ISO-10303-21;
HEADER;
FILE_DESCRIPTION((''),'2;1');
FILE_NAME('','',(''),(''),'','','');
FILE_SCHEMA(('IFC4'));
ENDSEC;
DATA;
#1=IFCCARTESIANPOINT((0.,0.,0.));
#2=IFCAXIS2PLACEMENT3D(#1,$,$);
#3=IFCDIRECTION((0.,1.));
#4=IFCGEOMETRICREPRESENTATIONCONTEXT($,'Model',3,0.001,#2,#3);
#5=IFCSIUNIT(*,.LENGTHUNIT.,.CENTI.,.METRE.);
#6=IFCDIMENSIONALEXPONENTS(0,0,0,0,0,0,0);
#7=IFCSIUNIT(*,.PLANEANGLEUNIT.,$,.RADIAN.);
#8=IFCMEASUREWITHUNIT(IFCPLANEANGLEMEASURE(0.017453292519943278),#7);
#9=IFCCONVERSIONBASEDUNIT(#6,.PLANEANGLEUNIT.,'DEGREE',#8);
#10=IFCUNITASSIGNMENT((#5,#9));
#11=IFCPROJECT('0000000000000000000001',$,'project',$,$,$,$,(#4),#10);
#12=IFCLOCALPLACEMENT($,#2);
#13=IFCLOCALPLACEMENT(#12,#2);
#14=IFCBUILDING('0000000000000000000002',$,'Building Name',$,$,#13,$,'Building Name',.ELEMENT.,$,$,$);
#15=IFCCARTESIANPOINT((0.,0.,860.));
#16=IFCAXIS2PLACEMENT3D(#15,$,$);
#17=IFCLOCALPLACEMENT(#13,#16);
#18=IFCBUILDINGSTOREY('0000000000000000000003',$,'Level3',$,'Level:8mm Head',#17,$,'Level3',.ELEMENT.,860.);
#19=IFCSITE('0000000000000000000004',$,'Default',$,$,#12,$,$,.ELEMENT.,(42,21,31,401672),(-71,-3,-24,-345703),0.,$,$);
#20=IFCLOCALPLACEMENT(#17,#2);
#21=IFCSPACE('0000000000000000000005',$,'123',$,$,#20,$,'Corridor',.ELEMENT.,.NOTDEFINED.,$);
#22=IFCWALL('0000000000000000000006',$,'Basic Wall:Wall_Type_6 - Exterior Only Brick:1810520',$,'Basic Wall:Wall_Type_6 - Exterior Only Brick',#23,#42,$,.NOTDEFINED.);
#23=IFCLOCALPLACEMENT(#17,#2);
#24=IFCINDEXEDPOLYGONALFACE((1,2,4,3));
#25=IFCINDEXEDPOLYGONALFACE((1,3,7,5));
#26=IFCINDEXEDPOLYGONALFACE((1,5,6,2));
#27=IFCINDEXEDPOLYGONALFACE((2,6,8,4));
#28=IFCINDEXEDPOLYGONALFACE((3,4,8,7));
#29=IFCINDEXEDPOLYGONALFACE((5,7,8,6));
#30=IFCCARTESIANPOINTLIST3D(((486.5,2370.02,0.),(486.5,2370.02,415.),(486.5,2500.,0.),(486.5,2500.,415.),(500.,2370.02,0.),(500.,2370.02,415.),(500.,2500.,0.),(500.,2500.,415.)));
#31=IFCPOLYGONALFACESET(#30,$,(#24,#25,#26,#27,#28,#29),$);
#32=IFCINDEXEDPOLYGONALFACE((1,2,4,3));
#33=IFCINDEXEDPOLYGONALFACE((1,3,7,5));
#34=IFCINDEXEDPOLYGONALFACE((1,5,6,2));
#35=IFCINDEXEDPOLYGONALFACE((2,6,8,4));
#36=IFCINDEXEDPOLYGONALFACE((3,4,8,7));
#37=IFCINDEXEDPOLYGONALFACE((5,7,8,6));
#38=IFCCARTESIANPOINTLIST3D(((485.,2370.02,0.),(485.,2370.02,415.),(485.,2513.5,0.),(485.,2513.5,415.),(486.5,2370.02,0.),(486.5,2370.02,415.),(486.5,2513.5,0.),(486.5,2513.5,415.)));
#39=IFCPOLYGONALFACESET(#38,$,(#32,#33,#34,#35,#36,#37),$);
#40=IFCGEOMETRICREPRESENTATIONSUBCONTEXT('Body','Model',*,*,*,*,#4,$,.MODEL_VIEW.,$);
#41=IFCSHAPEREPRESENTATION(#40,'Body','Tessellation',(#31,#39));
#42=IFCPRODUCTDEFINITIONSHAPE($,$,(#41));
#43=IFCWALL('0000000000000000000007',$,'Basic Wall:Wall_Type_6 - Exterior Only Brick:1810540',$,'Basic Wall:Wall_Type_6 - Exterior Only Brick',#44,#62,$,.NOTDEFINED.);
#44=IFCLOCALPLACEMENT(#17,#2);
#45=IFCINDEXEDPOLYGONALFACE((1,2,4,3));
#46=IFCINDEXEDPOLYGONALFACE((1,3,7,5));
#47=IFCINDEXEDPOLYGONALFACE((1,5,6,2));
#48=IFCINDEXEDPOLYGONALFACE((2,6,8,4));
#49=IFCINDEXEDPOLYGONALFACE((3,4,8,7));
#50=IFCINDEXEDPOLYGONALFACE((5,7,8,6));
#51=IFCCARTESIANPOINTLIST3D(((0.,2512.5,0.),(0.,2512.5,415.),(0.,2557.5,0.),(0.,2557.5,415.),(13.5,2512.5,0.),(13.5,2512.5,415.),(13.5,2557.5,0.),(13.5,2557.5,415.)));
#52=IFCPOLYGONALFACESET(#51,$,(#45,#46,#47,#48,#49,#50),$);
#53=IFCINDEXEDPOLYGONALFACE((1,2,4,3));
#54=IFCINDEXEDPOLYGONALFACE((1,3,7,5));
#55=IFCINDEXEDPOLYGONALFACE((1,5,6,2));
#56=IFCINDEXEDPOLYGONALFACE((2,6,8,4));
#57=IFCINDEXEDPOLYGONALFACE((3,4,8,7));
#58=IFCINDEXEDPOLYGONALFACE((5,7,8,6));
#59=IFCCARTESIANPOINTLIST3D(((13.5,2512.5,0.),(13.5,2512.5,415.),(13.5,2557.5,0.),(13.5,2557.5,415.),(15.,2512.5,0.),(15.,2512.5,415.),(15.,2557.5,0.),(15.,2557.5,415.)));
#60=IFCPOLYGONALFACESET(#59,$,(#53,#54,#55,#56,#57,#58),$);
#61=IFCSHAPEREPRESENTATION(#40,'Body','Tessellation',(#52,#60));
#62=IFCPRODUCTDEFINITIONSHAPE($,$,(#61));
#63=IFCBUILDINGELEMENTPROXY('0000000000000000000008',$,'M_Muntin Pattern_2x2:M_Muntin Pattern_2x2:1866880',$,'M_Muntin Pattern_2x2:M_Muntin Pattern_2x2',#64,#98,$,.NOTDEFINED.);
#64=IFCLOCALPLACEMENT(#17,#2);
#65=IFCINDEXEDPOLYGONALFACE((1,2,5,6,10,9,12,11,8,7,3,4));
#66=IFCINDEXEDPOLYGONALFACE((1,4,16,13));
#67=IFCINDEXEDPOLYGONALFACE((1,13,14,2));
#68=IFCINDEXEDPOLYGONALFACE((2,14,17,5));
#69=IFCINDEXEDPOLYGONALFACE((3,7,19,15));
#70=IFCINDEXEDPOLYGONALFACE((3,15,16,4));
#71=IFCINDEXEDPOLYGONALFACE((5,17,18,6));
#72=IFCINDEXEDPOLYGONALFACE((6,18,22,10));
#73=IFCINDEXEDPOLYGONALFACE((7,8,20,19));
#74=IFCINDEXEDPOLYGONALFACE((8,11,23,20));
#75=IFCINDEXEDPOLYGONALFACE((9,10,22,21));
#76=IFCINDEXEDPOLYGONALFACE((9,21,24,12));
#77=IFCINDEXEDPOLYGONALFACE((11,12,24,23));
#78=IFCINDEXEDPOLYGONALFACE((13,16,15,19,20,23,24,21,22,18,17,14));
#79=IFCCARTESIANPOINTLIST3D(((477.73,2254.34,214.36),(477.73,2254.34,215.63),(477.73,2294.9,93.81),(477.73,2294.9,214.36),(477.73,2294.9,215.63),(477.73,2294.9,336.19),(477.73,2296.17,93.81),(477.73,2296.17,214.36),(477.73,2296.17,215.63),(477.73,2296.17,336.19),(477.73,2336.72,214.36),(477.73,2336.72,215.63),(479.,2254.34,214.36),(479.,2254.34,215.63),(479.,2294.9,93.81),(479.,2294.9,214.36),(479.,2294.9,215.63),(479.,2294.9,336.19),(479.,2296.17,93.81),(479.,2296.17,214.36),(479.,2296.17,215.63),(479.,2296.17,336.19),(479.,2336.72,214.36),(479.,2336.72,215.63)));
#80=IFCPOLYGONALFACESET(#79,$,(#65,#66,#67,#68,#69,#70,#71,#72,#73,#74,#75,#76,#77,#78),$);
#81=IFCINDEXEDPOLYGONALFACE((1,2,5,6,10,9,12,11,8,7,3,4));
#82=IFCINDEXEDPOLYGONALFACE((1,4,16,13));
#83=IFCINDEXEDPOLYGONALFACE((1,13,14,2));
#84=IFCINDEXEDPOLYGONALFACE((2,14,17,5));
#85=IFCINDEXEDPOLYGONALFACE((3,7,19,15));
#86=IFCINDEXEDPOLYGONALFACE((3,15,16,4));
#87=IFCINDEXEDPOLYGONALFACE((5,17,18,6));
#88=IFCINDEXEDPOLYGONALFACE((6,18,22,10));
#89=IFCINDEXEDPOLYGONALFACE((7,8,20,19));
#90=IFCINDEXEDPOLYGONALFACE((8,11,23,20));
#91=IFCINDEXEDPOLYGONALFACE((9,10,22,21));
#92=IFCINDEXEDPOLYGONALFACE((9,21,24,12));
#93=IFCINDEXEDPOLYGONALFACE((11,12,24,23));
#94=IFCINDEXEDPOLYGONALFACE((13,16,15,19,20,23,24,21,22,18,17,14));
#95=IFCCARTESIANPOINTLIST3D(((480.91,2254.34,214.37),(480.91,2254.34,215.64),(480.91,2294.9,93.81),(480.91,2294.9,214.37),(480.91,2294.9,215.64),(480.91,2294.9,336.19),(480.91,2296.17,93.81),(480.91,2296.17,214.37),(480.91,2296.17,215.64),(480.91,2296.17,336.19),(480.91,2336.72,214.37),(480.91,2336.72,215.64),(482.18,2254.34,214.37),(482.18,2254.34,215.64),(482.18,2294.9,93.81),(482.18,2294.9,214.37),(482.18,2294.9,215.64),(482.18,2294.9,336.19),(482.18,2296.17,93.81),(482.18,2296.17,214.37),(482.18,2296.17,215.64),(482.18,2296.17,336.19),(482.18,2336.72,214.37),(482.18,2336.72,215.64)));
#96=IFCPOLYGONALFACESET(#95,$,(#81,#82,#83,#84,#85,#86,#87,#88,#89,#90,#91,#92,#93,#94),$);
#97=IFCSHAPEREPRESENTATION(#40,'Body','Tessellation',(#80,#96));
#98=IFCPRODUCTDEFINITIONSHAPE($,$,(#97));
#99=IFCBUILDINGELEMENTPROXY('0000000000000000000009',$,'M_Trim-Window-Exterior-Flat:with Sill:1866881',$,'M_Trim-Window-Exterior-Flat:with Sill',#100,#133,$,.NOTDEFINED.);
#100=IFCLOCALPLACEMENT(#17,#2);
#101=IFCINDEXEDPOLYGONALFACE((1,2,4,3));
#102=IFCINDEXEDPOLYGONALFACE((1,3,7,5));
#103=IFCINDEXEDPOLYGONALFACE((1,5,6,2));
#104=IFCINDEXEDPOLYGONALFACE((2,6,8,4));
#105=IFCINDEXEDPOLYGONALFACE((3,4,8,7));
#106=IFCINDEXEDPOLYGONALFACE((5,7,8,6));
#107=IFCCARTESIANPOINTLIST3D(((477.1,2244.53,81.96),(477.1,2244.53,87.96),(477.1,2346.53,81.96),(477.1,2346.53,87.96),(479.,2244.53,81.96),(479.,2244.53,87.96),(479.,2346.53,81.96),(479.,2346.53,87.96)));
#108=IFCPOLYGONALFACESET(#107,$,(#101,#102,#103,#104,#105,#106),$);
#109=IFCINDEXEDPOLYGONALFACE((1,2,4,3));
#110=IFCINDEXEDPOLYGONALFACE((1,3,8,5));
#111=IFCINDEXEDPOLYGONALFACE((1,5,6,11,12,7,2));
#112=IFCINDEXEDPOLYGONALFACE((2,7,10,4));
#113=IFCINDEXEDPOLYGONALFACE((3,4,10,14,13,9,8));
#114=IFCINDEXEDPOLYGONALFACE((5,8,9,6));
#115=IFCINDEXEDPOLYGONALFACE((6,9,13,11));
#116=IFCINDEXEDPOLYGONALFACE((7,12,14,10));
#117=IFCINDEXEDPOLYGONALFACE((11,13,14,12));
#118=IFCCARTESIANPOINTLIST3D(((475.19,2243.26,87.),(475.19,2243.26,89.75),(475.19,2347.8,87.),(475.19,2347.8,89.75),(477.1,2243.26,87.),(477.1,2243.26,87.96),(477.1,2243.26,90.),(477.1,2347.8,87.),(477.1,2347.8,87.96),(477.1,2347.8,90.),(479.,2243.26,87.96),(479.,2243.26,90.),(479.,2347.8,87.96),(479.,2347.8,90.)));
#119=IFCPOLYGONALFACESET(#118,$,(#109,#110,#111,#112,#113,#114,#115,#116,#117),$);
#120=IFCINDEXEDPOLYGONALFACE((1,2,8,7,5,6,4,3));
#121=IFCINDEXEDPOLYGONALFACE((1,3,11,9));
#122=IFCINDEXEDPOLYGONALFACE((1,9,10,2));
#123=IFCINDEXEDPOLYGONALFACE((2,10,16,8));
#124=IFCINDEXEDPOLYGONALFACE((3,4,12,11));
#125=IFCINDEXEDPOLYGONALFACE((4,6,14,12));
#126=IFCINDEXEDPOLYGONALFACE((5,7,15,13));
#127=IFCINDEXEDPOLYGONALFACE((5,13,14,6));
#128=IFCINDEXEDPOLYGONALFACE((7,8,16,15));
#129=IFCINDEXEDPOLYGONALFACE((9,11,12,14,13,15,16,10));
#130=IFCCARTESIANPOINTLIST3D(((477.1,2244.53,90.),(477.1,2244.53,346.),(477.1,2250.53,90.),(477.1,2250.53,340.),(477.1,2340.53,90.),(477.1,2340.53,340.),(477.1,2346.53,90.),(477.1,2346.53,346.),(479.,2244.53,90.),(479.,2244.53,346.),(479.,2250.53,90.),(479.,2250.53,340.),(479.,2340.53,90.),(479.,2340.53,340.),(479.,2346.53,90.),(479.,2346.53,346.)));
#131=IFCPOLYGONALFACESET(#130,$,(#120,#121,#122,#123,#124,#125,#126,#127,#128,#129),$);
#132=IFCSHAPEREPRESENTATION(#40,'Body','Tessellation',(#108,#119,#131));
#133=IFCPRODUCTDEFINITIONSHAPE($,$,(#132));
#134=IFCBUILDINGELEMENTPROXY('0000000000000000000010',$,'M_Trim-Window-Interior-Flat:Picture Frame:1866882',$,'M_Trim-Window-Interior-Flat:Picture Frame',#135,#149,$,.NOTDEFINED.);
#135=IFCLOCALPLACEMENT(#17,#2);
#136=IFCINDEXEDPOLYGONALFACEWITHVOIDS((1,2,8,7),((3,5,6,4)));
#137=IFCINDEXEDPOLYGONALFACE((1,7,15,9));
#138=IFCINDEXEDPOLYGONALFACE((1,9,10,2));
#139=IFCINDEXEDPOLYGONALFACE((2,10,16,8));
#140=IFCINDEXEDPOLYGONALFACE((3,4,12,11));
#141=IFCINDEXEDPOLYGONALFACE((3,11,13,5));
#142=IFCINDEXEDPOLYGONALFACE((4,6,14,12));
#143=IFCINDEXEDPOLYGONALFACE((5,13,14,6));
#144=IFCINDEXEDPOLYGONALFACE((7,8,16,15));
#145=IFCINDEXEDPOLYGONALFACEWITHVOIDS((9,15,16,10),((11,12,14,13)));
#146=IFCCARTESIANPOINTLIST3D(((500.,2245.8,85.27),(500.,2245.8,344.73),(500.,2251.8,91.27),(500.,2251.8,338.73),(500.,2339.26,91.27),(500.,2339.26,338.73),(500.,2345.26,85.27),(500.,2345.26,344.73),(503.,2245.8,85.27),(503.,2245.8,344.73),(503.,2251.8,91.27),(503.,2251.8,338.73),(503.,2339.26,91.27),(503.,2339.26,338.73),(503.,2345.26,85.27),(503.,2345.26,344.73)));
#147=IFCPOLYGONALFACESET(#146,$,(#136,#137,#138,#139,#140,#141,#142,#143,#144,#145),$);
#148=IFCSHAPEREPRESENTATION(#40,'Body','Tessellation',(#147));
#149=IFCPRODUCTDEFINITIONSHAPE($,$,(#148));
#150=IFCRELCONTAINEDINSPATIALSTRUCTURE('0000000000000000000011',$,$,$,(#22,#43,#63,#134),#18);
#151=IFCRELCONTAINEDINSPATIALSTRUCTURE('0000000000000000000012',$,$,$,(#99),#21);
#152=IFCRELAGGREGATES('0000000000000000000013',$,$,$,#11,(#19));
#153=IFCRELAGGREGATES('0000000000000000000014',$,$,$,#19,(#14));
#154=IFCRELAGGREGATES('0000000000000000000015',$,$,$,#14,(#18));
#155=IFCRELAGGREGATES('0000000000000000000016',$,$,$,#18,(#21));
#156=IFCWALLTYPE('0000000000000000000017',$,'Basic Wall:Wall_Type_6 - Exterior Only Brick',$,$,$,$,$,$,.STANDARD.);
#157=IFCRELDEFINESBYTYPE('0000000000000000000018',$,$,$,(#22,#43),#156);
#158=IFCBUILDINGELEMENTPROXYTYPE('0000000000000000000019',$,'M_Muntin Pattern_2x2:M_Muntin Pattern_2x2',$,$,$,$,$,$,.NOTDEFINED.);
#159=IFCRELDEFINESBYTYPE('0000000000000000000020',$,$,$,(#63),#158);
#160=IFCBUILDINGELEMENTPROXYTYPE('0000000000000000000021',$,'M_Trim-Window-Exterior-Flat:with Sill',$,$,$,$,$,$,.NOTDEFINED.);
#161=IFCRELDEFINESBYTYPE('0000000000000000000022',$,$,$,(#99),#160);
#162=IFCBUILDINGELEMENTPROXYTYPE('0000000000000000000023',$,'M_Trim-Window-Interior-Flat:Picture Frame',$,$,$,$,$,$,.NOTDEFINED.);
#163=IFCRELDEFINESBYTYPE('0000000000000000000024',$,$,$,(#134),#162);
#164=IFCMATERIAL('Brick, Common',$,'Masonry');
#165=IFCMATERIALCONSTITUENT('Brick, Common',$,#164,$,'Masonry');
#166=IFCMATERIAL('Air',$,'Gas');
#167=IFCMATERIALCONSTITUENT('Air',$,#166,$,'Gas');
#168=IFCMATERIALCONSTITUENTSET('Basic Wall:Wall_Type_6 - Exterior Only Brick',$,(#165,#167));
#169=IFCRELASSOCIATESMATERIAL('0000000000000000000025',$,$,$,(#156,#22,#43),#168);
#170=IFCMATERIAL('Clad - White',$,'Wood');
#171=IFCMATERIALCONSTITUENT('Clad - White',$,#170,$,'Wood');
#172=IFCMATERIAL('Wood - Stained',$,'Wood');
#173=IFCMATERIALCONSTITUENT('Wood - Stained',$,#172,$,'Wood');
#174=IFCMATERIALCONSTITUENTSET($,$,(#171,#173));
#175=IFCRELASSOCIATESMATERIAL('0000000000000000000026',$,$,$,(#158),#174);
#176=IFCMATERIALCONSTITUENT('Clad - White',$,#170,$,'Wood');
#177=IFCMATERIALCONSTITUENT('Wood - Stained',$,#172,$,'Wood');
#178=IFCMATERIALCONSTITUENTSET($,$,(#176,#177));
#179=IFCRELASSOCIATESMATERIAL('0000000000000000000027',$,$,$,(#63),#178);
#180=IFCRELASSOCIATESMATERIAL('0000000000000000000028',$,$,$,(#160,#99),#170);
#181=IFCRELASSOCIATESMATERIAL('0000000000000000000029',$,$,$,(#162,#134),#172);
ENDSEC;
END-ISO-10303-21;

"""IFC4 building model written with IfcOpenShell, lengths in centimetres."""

from ifc_helpers import new_model, entity, si_unit, converted_unit, direction, frame, origin, place, context, subcontext, project, spatial, indexed_curve, outline, extrude, source, transform, mapped, material, constituent, constituent_set, type_object, type_shapes, element, save


model = new_model("IFC4")

# Units and contexts
model_context = context("Model", 3, precision=0.001, world=origin(), true_north=direction((0.0, 1.0)))
body_context = subcontext(model_context, "Body", "Model", "MODEL_VIEW")
ifc_project = project(units=[si_unit("LENGTHUNIT", "METRE", prefix="CENTI"), converted_unit("PLANEANGLEUNIT", "DEGREE", entity("IfcPlaneAngleMeasure", 0.017453292519943278), si_unit("PLANEANGLEUNIT", "RADIAN"), dimensions=[0, 0, 0, 0, 0, 0, 0])], contexts=[model_context])

# Site, building, storey
site_placement = place(None, origin())
site = spatial("IfcSite", under=ifc_project, at=site_placement, Name="Default", CompositionType="ELEMENT", RefLatitude=(42, 21, 31, 401672), RefLongitude=(-71, -3, -24, -345703), RefElevation=0.0)
building_placement = place(site_placement, origin())
building = spatial("IfcBuilding", under=site, at=building_placement, Name="Building Name", LongName="Building Name", CompositionType="ELEMENT")
storey_placement = place(building_placement, frame((0.0, 0.0, 860.0)))
storey = spatial("IfcBuildingStorey", under=building, at=storey_placement, Name="Level3", ObjectType="Level:8mm Head", LongName="Level3", CompositionType="ELEMENT", Elevation=860.0)

# Shared definitions
ifc_material_1 = material(Name="Brick, Common", Category="Masonry")
ifc_material_2 = material(Name="Air", Category="Gas")

# Walls
ifc_constituent_1 = constituent(ifc_material_1, Name="Brick, Common", Category="Masonry")
ifc_constituent_2 = constituent(ifc_material_2, Name="Air", Category="Gas")
ifc_constituent_set_1 = constituent_set(constituents=[ifc_constituent_1, ifc_constituent_2], Name="Basic Wall:Wall_Type_6 - Exterior Only Brick")
wall_type_1 = type_object("IfcWallType", Name="Basic Wall:Wall_Type_6 - Exterior Only Brick", PredefinedType="STANDARD", material=ifc_constituent_set_1)
wall_1_placement = place(storey_placement, frame((492.5, 2500.0, 0.0), z_axis=(0.0, 0.0, 1.0), x_axis=(0.0, -1.0, 0.0)))
element("IfcWall", 1, at=wall_1_placement, inside=storey, type_object=wall_type_1, material=ifc_constituent_set_1, Name="Basic Wall:Wall_Type_6 - Exterior Only Brick:1810520", ObjectType="Basic Wall:Wall_Type_6 - Exterior Only Brick", PredefinedType="NOTDEFINED", context=body_context, shape_type="SweptSolid", body=[
    extrude(outline(indexed_curve([(-6.75, -64.99), (6.75, -64.99), (6.75, 64.99), (-6.75, 64.99), (-6.75, -64.99)], self_intersect=False)), frame((64.99, 0.75, 0.0), z_axis=(0.0, 0.0, 1.0), x_axis=(0.0, -1.0, 0.0)), (0.0, 0.0, 1.0), 415.0),
    extrude(outline(indexed_curve([(-0.75, -71.74), (0.75, -71.74), (0.75, 71.74), (-0.75, 71.74), (-0.75, -71.74)], self_intersect=False)), frame((58.24, -6.75, 0.0), z_axis=(0.0, 0.0, 1.0), x_axis=(0.0, 1.0, 0.0)), (0.0, 0.0, 1.0), 415.0),
])
wall_2_placement = place(storey_placement, frame((7.5, 2512.5, 0.0), z_axis=(0.0, 0.0, 1.0), x_axis=(0.0, 1.0, 0.0)))
element("IfcWall", 2, at=wall_2_placement, inside=storey, type_object=wall_type_1, material=ifc_constituent_set_1, Name="Basic Wall:Wall_Type_6 - Exterior Only Brick:1810540", ObjectType="Basic Wall:Wall_Type_6 - Exterior Only Brick", PredefinedType="NOTDEFINED", context=body_context, shape_type="SweptSolid", body=[
    extrude(outline(indexed_curve([(-6.75, -22.5), (6.75, -22.5), (6.75, 22.5), (-6.75, 22.5), (-6.75, -22.5)], self_intersect=False)), frame((22.5, 0.75, 0.0), z_axis=(0.0, 0.0, 1.0), x_axis=(0.0, -1.0, 0.0)), (0.0, 0.0, 1.0), 415.0),
    extrude(outline(indexed_curve([(-0.75, -22.5), (0.75, -22.5), (0.75, 22.5), (-0.75, 22.5), (-0.75, -22.5)], self_intersect=False)), frame((22.5, -6.75, 0.0), z_axis=(0.0, 0.0, 1.0), x_axis=(0.0, 1.0, 0.0)), (0.0, 0.0, 1.0), 415.0),
])

# Building element proxy
ifc_material_3 = material(Name="Clad - White", Category="Wood")
ifc_constituent_3 = constituent(ifc_material_3, Name="Clad - White", Category="Wood")
ifc_material_4 = material(Name="Wood - Stained", Category="Wood")
ifc_constituent_4 = constituent(ifc_material_4, Name="Wood - Stained", Category="Wood")
ifc_constituent_set_2 = constituent_set(constituents=[ifc_constituent_3, ifc_constituent_4])
ifc_constituent_5 = constituent(ifc_material_3, Name="Clad - White", Category="Wood")
ifc_constituent_6 = constituent(ifc_material_4, Name="Wood - Stained", Category="Wood")
ifc_constituent_set_3 = constituent_set(constituents=[ifc_constituent_5, ifc_constituent_6])
building_element_proxy_type_1 = type_object("IfcBuildingElementProxyType", Name="M_Muntin Pattern_2x2:M_Muntin Pattern_2x2", PredefinedType="NOTDEFINED", material=ifc_constituent_set_3)
shared_shape_1 = source(origin(), body_context, "Body", "SweptSolid", [
    extrude(outline(indexed_curve([(0.64, -0.64), (121.19, -0.64), (121.19, 0.63), (0.64, 0.63), (0.64, 41.19), (-0.63, 41.19), (-0.63, 0.63), (-121.19, 0.63), (-121.19, -0.64), (-0.63, -0.64), (-0.63, -41.19), (0.64, -41.19), (0.64, -0.64)], self_intersect=False)), frame((0.0, 0.95, 121.19), z_axis=(0.0, 1.0, 0.0), x_axis=(0.0, 0.0, 1.0)), (0.0, 0.0, 1.0), 1.27),
    extrude(outline(indexed_curve([(0.64, -0.64), (121.19, -0.64), (121.19, 0.63), (0.64, 0.63), (0.64, 41.19), (-0.63, 41.19), (-0.63, 0.63), (-121.19, 0.63), (-121.19, -0.64), (-0.63, -0.64), (-0.63, -41.19), (0.64, -41.19), (0.64, -0.64)], self_intersect=False)), frame((0.0, -2.22, 121.19), z_axis=(0.0, 1.0, 0.0), x_axis=(0.0, 0.0, 1.0)), (0.0, 0.0, 1.0), 1.27),
])
type_shapes(building_element_proxy_type_1, [shared_shape_1])
proxy_1_placement = place(storey_placement, frame((479.95, 2295.53, 93.81), z_axis=(0.0, 0.0, 1.0), x_axis=(0.0, 1.0, 0.0)))
element("IfcBuildingElementProxy", 3, at=proxy_1_placement, inside=storey, type_object=building_element_proxy_type_1, material=ifc_constituent_set_2, Name="M_Muntin Pattern_2x2:M_Muntin Pattern_2x2:1866880", ObjectType="M_Muntin Pattern_2x2:M_Muntin Pattern_2x2", PredefinedType="NOTDEFINED", context=body_context, shape_type="MappedRepresentation", body=[
    mapped(shared_shape_1, transform((0.0, 0.0, 0.0), scale=1.0)),
])

# Shared definitions
space_1_placement = place(storey_placement, origin())
space_1 = spatial("IfcSpace", under=storey, at=space_1_placement, Name="123", LongName="Corridor", CompositionType="ELEMENT", PredefinedType="NOTDEFINED")

# Building element proxies
building_element_proxy_type_2 = type_object("IfcBuildingElementProxyType", Name="M_Trim-Window-Exterior-Flat:with Sill", PredefinedType="NOTDEFINED", material=ifc_material_3)
shared_shape_2 = source(origin(), body_context, "Body", "SweptSolid", [
    extrude(outline(indexed_curve([(-3.0, -51.0), (3.0, -51.0), (3.0, 51.0), (-3.0, 51.0), (-3.0, -51.0)], self_intersect=False)), frame((0.0, 255.04, 0.0), z_axis=(0.0, 0.0, 1.0), x_axis=(0.0, 1.0, 0.0)), (0.0, 0.0, 1.0), 1.9),
    extrude(outline(indexed_curve([(-1.52, -1.9), (1.23, -1.9), (1.48, 0.0), (1.48, 1.9), (-0.57, 1.9), (-0.57, 0.0), (-1.52, 0.0), (-1.52, -1.9)], self_intersect=False)), frame((-52.27, 251.48, 1.9), z_axis=(1.0, 0.0, 0.0), x_axis=(0.0, -1.0, 0.0)), (0.0, 0.0, 1.0), 104.54),
    extrude(outline(indexed_curve([(-51.0, -129.5), (51.0, -129.5), (51.0, 126.5), (45.0, 126.5), (45.0, -123.5), (-45.0, -123.5), (-45.0, 126.5), (-51.0, 126.5), (-51.0, -129.5)], self_intersect=False)), frame((0.0, 123.5, 0.0)), (0.0, 0.0, 1.0), 1.9),
])
type_shapes(building_element_proxy_type_2, [shared_shape_2])
proxy_2_placement = place(space_1_placement, frame((479.0, 2295.53, 340.0), z_axis=(-1.0, 0.0, 0.0), x_axis=(0.0, 1.0, 0.0)))
element("IfcBuildingElementProxy", 4, at=proxy_2_placement, inside=space_1, type_object=building_element_proxy_type_2, material=ifc_material_3, Name="M_Trim-Window-Exterior-Flat:with Sill:1866881", ObjectType="M_Trim-Window-Exterior-Flat:with Sill", PredefinedType="NOTDEFINED", context=body_context, shape_type="MappedRepresentation", body=[
    mapped(shared_shape_2, transform((0.0, 0.0, 0.0), scale=1.0)),
])
building_element_proxy_type_3 = type_object("IfcBuildingElementProxyType", Name="M_Trim-Window-Interior-Flat:Picture Frame", PredefinedType="NOTDEFINED", material=ifc_material_4)
shared_shape_3 = source(origin(), body_context, "Body", "SweptSolid", [
    extrude(outline(indexed_curve([(-129.73, -49.73), (129.73, -49.73), (129.73, 49.73), (-129.73, 49.73), (-129.73, -49.73)], self_intersect=False), holes=[indexed_curve([(-123.73, -43.73), (-123.73, 43.73), (123.73, 43.73), (123.73, -43.73), (-123.73, -43.73)], self_intersect=False)]), frame((0.0, 125.0, 0.0), z_axis=(0.0, 0.0, 1.0), x_axis=(0.0, 1.0, 0.0)), (0.0, 0.0, 1.0), 3.0),
])
type_shapes(building_element_proxy_type_3, [shared_shape_3])
proxy_3_placement = place(storey_placement, frame((500.0, 2295.53, 340.0), z_axis=(1.0, 0.0, 0.0), x_axis=(0.0, -1.0, 0.0)))
element("IfcBuildingElementProxy", 5, at=proxy_3_placement, inside=storey, type_object=building_element_proxy_type_3, material=ifc_material_4, Name="M_Trim-Window-Interior-Flat:Picture Frame:1866882", ObjectType="M_Trim-Window-Interior-Flat:Picture Frame", PredefinedType="NOTDEFINED", context=body_context, shape_type="MappedRepresentation", body=[
    mapped(shared_shape_3, transform((0.0, 0.0, 0.0), scale=1.0)),
])

save(model, "model.ifc")
